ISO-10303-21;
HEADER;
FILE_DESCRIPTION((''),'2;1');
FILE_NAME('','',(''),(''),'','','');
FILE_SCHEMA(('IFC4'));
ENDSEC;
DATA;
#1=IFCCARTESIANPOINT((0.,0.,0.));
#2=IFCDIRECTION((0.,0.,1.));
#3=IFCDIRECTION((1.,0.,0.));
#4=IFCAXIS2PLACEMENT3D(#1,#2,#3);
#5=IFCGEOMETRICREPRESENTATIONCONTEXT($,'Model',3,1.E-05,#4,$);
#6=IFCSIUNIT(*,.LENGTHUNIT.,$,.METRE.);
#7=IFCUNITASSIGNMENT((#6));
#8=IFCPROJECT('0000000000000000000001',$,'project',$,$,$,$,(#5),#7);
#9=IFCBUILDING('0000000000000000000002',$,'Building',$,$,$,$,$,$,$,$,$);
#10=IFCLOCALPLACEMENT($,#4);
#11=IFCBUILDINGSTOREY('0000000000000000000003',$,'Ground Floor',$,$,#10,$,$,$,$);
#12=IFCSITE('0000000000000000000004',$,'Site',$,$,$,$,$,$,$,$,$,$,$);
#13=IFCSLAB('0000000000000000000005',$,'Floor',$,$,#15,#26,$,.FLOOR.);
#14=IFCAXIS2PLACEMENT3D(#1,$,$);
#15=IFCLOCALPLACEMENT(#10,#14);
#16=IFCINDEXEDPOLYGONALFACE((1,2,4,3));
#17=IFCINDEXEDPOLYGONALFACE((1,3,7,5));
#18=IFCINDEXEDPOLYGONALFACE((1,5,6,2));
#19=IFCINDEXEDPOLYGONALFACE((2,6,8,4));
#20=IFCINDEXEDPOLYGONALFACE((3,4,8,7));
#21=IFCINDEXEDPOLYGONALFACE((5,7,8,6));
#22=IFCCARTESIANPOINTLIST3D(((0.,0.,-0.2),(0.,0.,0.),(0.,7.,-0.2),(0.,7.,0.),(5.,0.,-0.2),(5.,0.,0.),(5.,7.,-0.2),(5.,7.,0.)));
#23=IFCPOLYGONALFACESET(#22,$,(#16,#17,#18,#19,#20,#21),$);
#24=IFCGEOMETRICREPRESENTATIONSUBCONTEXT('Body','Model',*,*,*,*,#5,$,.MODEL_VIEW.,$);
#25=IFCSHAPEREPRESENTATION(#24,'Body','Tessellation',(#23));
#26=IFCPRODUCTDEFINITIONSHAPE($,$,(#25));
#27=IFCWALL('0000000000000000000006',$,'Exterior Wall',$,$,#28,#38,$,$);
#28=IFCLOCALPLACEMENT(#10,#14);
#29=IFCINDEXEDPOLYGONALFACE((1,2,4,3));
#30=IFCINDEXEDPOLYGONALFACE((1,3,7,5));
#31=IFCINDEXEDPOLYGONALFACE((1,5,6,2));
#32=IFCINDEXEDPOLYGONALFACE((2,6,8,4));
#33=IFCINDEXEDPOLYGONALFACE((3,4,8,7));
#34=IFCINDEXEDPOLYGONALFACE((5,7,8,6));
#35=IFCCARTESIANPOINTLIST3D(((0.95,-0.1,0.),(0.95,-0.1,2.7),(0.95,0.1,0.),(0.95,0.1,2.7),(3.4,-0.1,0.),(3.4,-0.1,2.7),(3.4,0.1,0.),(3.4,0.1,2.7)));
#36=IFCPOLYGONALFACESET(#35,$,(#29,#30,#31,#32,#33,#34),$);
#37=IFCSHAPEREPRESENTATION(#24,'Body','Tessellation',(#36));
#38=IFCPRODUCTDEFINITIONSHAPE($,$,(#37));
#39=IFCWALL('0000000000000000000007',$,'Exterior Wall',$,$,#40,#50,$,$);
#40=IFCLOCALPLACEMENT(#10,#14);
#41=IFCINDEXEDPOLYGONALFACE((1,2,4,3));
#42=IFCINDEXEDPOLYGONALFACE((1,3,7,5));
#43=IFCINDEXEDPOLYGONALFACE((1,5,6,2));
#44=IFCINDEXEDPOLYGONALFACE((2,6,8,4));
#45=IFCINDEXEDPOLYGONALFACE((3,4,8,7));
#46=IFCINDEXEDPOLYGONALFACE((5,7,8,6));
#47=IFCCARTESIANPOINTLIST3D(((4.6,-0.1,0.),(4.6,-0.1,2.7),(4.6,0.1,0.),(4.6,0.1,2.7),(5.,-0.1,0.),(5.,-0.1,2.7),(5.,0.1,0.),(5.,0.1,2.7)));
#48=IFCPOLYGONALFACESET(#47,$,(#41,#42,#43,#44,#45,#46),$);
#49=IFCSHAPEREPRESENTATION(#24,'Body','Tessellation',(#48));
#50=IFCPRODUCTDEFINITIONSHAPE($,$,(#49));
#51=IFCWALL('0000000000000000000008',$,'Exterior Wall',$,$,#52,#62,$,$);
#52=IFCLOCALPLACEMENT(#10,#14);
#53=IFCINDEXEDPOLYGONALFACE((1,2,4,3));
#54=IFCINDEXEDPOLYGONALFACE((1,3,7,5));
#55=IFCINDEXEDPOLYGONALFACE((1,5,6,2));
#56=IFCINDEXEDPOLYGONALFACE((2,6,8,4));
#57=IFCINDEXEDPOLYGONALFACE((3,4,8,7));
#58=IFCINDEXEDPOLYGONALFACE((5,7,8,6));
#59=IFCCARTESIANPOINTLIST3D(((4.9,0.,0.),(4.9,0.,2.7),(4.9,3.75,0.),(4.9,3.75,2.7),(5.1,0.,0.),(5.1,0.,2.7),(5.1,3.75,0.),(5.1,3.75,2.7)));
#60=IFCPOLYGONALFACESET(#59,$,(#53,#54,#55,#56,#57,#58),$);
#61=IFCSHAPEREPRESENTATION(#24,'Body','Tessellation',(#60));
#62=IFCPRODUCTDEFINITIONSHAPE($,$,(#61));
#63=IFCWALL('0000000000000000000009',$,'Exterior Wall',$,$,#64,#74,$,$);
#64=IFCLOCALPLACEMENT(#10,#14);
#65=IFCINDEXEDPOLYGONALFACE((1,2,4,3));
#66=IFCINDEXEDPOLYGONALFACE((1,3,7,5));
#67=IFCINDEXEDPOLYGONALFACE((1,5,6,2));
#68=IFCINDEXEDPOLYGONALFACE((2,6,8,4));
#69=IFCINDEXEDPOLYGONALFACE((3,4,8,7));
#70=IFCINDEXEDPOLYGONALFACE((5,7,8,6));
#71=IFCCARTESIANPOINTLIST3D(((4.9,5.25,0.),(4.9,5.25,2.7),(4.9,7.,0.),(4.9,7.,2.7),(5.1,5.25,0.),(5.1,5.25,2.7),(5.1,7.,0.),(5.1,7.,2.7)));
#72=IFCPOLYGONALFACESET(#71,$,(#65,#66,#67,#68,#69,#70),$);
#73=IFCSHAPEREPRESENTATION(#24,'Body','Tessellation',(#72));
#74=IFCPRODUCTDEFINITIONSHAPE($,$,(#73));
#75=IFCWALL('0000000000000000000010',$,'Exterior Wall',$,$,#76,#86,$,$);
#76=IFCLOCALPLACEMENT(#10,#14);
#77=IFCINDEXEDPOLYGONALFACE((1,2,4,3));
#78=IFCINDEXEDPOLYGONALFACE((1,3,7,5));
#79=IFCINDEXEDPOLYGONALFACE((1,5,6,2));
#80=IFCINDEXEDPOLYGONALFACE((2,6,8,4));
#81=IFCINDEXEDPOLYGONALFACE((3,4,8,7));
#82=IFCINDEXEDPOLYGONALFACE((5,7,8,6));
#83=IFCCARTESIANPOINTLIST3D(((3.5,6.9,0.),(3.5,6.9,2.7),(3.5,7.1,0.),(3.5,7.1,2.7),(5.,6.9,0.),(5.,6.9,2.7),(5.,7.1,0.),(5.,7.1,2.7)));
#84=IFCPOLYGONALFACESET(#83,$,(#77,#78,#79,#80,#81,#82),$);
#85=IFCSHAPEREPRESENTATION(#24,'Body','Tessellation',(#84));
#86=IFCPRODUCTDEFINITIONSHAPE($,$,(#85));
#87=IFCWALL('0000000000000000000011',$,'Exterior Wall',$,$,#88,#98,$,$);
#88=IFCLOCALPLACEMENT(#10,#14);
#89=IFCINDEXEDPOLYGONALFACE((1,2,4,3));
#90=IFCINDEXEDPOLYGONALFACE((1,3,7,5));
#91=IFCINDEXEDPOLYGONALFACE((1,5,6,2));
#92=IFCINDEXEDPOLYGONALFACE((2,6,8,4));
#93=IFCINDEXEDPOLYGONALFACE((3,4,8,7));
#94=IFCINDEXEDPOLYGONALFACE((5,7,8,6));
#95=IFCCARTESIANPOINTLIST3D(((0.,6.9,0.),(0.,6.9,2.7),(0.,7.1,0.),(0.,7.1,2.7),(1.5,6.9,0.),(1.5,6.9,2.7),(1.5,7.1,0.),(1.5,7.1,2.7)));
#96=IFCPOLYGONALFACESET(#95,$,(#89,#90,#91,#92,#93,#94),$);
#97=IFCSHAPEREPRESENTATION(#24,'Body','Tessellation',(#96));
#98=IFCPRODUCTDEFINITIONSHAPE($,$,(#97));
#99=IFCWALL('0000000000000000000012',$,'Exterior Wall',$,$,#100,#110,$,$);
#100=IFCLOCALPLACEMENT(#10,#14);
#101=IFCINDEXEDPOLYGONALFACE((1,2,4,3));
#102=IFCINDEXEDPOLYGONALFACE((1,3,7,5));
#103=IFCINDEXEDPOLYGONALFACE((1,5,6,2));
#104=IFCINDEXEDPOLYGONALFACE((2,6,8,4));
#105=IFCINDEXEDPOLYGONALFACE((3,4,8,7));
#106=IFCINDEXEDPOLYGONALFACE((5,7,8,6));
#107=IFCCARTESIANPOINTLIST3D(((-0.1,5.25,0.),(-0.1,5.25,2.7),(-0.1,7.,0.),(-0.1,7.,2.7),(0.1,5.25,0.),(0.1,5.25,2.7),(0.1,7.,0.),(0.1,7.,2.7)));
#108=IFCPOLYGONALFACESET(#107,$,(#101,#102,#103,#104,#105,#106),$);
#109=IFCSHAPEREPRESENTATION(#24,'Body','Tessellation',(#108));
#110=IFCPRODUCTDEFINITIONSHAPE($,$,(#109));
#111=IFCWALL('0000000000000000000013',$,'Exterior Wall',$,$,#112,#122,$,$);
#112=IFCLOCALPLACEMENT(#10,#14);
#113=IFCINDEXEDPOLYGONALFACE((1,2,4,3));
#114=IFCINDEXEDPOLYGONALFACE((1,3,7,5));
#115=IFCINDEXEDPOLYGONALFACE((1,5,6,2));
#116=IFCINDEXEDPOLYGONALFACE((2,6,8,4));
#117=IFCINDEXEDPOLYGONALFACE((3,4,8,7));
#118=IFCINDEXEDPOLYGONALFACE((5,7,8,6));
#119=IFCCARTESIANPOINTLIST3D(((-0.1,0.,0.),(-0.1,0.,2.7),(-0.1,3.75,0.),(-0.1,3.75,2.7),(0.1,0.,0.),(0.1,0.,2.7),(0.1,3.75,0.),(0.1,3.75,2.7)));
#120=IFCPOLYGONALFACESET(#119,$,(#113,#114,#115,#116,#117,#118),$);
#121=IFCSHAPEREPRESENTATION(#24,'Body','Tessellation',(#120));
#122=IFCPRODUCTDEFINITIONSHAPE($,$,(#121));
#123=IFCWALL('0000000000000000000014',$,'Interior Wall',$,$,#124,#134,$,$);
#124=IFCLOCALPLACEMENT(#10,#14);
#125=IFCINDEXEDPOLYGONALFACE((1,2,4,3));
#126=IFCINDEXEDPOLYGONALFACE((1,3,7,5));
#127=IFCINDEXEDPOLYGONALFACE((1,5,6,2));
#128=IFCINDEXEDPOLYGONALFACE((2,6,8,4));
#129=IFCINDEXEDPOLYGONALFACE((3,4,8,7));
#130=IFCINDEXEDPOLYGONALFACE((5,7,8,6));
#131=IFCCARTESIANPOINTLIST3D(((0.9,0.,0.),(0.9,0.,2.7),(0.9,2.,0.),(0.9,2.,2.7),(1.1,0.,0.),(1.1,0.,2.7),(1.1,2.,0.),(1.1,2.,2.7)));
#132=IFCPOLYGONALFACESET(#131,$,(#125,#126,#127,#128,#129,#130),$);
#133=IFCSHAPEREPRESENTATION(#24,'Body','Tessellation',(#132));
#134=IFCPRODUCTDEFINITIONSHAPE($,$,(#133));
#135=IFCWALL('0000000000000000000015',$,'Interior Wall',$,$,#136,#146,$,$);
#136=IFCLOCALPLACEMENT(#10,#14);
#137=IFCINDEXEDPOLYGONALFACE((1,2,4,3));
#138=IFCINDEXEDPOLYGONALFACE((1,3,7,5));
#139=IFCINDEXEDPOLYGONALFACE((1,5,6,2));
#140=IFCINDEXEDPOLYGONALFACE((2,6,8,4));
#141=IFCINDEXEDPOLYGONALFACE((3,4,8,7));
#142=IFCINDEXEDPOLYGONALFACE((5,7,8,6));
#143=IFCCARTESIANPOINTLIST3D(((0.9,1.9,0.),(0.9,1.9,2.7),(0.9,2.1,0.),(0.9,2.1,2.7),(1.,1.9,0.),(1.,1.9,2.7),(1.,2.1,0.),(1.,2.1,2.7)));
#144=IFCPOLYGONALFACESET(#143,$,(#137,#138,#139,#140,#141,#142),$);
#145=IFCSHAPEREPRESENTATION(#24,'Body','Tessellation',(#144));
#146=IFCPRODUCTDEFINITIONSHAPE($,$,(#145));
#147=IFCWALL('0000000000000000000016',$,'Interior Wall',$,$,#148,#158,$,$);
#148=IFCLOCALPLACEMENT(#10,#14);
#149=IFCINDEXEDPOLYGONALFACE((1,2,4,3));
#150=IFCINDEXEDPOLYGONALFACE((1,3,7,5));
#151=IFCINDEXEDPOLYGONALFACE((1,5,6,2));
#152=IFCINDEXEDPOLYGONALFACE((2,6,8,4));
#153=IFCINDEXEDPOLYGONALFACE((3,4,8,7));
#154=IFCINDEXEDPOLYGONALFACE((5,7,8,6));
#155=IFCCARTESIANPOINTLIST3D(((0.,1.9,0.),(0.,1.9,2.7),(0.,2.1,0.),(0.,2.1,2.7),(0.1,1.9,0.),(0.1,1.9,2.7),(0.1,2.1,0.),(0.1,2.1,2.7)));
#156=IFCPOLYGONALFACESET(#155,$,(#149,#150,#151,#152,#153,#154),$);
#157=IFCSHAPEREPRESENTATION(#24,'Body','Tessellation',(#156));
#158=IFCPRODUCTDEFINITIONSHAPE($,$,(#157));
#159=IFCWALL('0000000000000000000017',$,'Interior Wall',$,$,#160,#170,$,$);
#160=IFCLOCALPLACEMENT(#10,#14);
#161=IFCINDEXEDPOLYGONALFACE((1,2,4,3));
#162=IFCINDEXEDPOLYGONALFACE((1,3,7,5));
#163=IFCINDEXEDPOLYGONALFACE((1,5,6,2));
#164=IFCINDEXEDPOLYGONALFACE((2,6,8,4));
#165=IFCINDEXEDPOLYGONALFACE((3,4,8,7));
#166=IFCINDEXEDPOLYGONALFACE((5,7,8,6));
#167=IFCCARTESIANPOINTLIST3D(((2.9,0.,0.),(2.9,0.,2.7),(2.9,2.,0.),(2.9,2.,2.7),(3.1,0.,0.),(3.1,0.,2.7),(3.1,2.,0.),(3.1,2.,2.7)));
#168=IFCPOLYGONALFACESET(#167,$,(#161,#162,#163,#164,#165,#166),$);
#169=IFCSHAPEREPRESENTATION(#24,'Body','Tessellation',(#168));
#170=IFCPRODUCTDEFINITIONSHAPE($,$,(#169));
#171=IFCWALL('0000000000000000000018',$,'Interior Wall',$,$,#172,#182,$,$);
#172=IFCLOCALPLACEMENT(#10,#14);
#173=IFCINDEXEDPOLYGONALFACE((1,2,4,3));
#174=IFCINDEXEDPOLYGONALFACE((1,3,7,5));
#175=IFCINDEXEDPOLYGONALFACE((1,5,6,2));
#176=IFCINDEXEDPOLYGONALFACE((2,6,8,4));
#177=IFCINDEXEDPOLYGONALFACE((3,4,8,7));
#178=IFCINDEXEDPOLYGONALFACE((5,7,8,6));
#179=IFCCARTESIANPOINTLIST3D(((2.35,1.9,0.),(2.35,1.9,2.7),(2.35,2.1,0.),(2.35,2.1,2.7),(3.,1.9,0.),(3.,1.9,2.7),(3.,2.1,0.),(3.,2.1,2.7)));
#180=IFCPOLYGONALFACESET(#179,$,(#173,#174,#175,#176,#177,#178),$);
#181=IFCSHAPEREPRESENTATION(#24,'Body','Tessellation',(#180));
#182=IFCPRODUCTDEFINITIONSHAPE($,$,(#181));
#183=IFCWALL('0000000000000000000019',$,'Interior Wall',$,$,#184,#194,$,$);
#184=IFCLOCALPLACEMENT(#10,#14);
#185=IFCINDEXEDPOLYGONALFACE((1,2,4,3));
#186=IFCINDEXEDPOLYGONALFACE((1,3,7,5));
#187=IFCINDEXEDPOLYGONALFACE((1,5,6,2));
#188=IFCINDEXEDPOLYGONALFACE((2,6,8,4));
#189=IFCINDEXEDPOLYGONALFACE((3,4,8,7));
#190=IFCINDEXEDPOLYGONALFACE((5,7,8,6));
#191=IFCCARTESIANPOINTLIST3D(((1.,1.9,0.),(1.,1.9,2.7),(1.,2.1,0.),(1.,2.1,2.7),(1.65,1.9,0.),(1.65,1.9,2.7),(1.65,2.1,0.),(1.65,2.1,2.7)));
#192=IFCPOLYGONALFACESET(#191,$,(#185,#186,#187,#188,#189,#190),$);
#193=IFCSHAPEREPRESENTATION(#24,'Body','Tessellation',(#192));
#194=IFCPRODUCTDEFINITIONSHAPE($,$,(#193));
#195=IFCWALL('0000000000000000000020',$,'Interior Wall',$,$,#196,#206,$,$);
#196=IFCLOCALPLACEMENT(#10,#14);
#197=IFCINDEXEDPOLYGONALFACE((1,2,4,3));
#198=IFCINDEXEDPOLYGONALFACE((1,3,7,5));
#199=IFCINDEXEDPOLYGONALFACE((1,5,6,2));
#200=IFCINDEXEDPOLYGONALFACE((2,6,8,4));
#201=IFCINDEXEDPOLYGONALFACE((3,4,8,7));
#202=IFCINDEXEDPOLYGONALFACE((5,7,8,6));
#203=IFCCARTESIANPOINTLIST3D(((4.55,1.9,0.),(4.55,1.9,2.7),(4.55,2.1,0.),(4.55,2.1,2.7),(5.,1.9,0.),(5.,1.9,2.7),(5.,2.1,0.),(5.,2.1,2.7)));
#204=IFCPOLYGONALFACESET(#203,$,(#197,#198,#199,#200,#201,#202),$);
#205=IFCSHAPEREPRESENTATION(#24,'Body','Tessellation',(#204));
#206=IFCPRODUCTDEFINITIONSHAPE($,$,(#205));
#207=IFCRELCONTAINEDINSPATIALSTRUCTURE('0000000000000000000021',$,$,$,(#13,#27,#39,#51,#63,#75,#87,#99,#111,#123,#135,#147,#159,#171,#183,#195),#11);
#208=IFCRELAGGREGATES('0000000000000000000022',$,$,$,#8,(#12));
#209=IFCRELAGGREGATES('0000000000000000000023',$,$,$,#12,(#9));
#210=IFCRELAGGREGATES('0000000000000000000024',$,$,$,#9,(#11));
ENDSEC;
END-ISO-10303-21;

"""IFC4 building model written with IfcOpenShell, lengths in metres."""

from ifc_helpers import new_model, si_unit, frame, origin_with_axes, place, context, subcontext, project, spatial, indexed_curve, outline, extrude, element, save


model = new_model("IFC4")

# Units and contexts
model_context = context("Model", 3, precision=1e-05, world=origin_with_axes())
body_context = subcontext(model_context, "Body", "Model", "MODEL_VIEW")
ifc_project = project(units=[si_unit("LENGTHUNIT", "METRE")], contexts=[model_context])

# Site, building, storey
site = spatial("IfcSite", under=ifc_project, Name="Site")
building = spatial("IfcBuilding", under=site, Name="Building")
storey_placement = place(None, origin_with_axes())
storey = spatial("IfcBuildingStorey", under=building, at=storey_placement, Name="Ground Floor")

# Slab
slab_placement = place(storey_placement, frame((0.0, 0.0, -0.2), z_axis=(0.0, 0.0, 1.0), x_axis=(1.0, 0.0, 0.0)))
element("IfcSlab", 1, at=slab_placement, inside=storey, Name="Floor", PredefinedType="FLOOR", context=body_context, shape_type="SweptSolid", body=[
    extrude(outline(indexed_curve([(0.0, 0.0), (5.0, 0.0), (5.0, 7.0), (0.0, 7.0)])), None, (0.0, 0.0, 1.0), 0.2),
])

# Walls
wall_1_placement = place(storey_placement, frame((0.95, 0.0, 0.0), z_axis=(0.0, 0.0, 1.0), x_axis=(1.0, 0.0, 0.0)))
element("IfcWall", 2, at=wall_1_placement, inside=storey, Name="Exterior Wall", context=body_context, shape_type="SweptSolid", body=[
    extrude(outline(indexed_curve([(0.0, 0.0), (0.0, 0.2), (2.45, 0.2), (2.45, 0.0), (0.0, 0.0)], self_intersect=False)), frame((0.0, -0.1, 0.0), z_axis=(0.0, 0.0, 1.0), x_axis=(1.0, 0.0, 0.0)), (0.0, 0.0, 1.0), 2.7),
])
wall_2_placement = place(storey_placement, frame((4.6, 0.0, 0.0), z_axis=(0.0, 0.0, 1.0), x_axis=(1.0, 0.0, 0.0)))
element("IfcWall", 3, at=wall_2_placement, inside=storey, Name="Exterior Wall", context=body_context, shape_type="SweptSolid", body=[
    extrude(outline(indexed_curve([(0.0, 0.0), (0.0, 0.2), (0.4, 0.2), (0.4, 0.0), (0.0, 0.0)], self_intersect=False)), frame((0.0, -0.1, 0.0), z_axis=(0.0, 0.0, 1.0), x_axis=(1.0, 0.0, 0.0)), (0.0, 0.0, 1.0), 2.7),
])
wall_3_placement = place(storey_placement, frame((5.0, 0.0, 0.0), z_axis=(0.0, 0.0, 1.0), x_axis=(0.0, 1.0, 0.0)))
element("IfcWall", 4, at=wall_3_placement, inside=storey, Name="Exterior Wall", context=body_context, shape_type="SweptSolid", body=[
    extrude(outline(indexed_curve([(0.0, 0.0), (0.0, 0.2), (3.75, 0.2), (3.75, 0.0), (0.0, 0.0)], self_intersect=False)), frame((0.0, -0.1, 0.0), z_axis=(0.0, 0.0, 1.0), x_axis=(1.0, 0.0, 0.0)), (0.0, 0.0, 1.0), 2.7),
])
wall_4_placement = place(storey_placement, frame((5.0, 5.25, 0.0), z_axis=(0.0, 0.0, 1.0), x_axis=(0.0, 1.0, 0.0)))
element("IfcWall", 5, at=wall_4_placement, inside=storey, Name="Exterior Wall", context=body_context, shape_type="SweptSolid", body=[
    extrude(outline(indexed_curve([(0.0, 0.0), (0.0, 0.2), (1.75, 0.2), (1.75, 0.0), (0.0, 0.0)], self_intersect=False)), frame((0.0, -0.1, 0.0), z_axis=(0.0, 0.0, 1.0), x_axis=(1.0, 0.0, 0.0)), (0.0, 0.0, 1.0), 2.7),
])
for number, where, z_axis, x_axis, name in (
    (6, (5.0, 7.0, 0.0), (0.0, 0.0, 1.0), (-1.0, 0.0, 0.0), "Exterior Wall"),
    (7, (1.5, 7.0, 0.0), (0.0, 0.0, 1.0), (-1.0, 0.0, 0.0), "Exterior Wall"),
):
    element("IfcWall", number, at=place(storey_placement, frame(where, z_axis=z_axis, x_axis=x_axis)), inside=storey, Name=name, context=body_context, shape_type="SweptSolid", body=[
        extrude(outline(indexed_curve([(0.0, 0.0), (0.0, 0.2), (1.5, 0.2), (1.5, 0.0), (0.0, 0.0)], self_intersect=False)), frame((0.0, -0.1, 0.0), z_axis=(0.0, 0.0, 1.0), x_axis=(1.0, 0.0, 0.0)), (0.0, 0.0, 1.0), 2.7),
    ])
wall_5_placement = place(storey_placement, frame((0.0, 7.0, 0.0), z_axis=(0.0, 0.0, 1.0), x_axis=(0.0, -1.0, 0.0)))
element("IfcWall", 8, at=wall_5_placement, inside=storey, Name="Exterior Wall", context=body_context, shape_type="SweptSolid", body=[
    extrude(outline(indexed_curve([(0.0, 0.0), (0.0, 0.2), (1.75, 0.2), (1.75, 0.0), (0.0, 0.0)], self_intersect=False)), frame((0.0, -0.1, 0.0), z_axis=(0.0, 0.0, 1.0), x_axis=(1.0, 0.0, 0.0)), (0.0, 0.0, 1.0), 2.7),
])
wall_6_placement = place(storey_placement, frame((0.0, 3.75, 0.0), z_axis=(0.0, 0.0, 1.0), x_axis=(0.0, -1.0, 0.0)))
element("IfcWall", 9, at=wall_6_placement, inside=storey, Name="Exterior Wall", context=body_context, shape_type="SweptSolid", body=[
    extrude(outline(indexed_curve([(0.0, 0.0), (0.0, 0.2), (3.75, 0.2), (3.75, 0.0), (0.0, 0.0)], self_intersect=False)), frame((0.0, -0.1, 0.0), z_axis=(0.0, 0.0, 1.0), x_axis=(1.0, 0.0, 0.0)), (0.0, 0.0, 1.0), 2.7),
])
wall_7_placement = place(storey_placement, frame((1.0, 0.0, 0.0), z_axis=(0.0, 0.0, 1.0), x_axis=(0.0, 1.0, 0.0)))
element("IfcWall", 10, at=wall_7_placement, inside=storey, Name="Interior Wall", context=body_context, shape_type="SweptSolid", body=[
    extrude(outline(indexed_curve([(0.0, 0.0), (0.0, 0.2), (2.0, 0.2), (2.0, 0.0), (0.0, 0.0)], self_intersect=False)), frame((0.0, -0.1, 0.0), z_axis=(0.0, 0.0, 1.0), x_axis=(1.0, 0.0, 0.0)), (0.0, 0.0, 1.0), 2.7),
])
for number, where, z_axis, x_axis, name in (
    (11, (1.0, 2.0, 0.0), (0.0, 0.0, 1.0), (-1.0, 0.0, 0.0), "Interior Wall"),
    (12, (0.1, 2.0, 0.0), (0.0, 0.0, 1.0), (-1.0, 0.0, 0.0), "Interior Wall"),
):
    element("IfcWall", number, at=place(storey_placement, frame(where, z_axis=z_axis, x_axis=x_axis)), inside=storey, Name=name, context=body_context, shape_type="SweptSolid", body=[
        extrude(outline(indexed_curve([(0.0, 0.0), (0.0, 0.2), (0.1, 0.2), (0.1, 0.0), (0.0, 0.0)], self_intersect=False)), frame((0.0, -0.1, 0.0), z_axis=(0.0, 0.0, 1.0), x_axis=(1.0, 0.0, 0.0)), (0.0, 0.0, 1.0), 2.7),
    ])
wall_8_placement = place(storey_placement, frame((3.0, 0.0, 0.0), z_axis=(0.0, 0.0, 1.0), x_axis=(0.0, 1.0, 0.0)))
element("IfcWall", 13, at=wall_8_placement, inside=storey, Name="Interior Wall", context=body_context, shape_type="SweptSolid", body=[
    extrude(outline(indexed_curve([(0.0, 0.0), (0.0, 0.2), (2.0, 0.2), (2.0, 0.0), (0.0, 0.0)], self_intersect=False)), frame((0.0, -0.1, 0.0), z_axis=(0.0, 0.0, 1.0), x_axis=(1.0, 0.0, 0.0)), (0.0, 0.0, 1.0), 2.7),
])
for number, where, z_axis, x_axis, name in (
    (14, (3.0, 2.0, 0.0), (0.0, 0.0, 1.0), (-1.0, 0.0, 0.0), "Interior Wall"),
    (15, (1.65, 2.0, 0.0), (0.0, 0.0, 1.0), (-1.0, 0.0, 0.0), "Interior Wall"),
):
    element("IfcWall", number, at=place(storey_placement, frame(where, z_axis=z_axis, x_axis=x_axis)), inside=storey, Name=name, context=body_context, shape_type="SweptSolid", body=[
        extrude(outline(indexed_curve([(0.0, 0.0), (0.0, 0.2), (0.65, 0.2), (0.65, 0.0), (0.0, 0.0)], self_intersect=False)), frame((0.0, -0.1, 0.0), z_axis=(0.0, 0.0, 1.0), x_axis=(1.0, 0.0, 0.0)), (0.0, 0.0, 1.0), 2.7),
    ])
for number, where, z_axis, x_axis, name in (
    (16, (5.0, 2.0, 0.0), (0.0, 0.0, 1.0), (-1.0, 0.0, 0.0), "Interior Wall"),
):
    element("IfcWall", number, at=place(storey_placement, frame(where, z_axis=z_axis, x_axis=x_axis)), inside=storey, Name=name, context=body_context, shape_type="SweptSolid", body=[
        extrude(outline(indexed_curve([(0.0, 0.0), (0.0, 0.2), (0.45, 0.2), (0.45, 0.0), (0.0, 0.0)], self_intersect=False)), frame((0.0, -0.1, 0.0), z_axis=(0.0, 0.0, 1.0), x_axis=(1.0, 0.0, 0.0)), (0.0, 0.0, 1.0), 2.7),
    ])

save(model, "model.ifc")
